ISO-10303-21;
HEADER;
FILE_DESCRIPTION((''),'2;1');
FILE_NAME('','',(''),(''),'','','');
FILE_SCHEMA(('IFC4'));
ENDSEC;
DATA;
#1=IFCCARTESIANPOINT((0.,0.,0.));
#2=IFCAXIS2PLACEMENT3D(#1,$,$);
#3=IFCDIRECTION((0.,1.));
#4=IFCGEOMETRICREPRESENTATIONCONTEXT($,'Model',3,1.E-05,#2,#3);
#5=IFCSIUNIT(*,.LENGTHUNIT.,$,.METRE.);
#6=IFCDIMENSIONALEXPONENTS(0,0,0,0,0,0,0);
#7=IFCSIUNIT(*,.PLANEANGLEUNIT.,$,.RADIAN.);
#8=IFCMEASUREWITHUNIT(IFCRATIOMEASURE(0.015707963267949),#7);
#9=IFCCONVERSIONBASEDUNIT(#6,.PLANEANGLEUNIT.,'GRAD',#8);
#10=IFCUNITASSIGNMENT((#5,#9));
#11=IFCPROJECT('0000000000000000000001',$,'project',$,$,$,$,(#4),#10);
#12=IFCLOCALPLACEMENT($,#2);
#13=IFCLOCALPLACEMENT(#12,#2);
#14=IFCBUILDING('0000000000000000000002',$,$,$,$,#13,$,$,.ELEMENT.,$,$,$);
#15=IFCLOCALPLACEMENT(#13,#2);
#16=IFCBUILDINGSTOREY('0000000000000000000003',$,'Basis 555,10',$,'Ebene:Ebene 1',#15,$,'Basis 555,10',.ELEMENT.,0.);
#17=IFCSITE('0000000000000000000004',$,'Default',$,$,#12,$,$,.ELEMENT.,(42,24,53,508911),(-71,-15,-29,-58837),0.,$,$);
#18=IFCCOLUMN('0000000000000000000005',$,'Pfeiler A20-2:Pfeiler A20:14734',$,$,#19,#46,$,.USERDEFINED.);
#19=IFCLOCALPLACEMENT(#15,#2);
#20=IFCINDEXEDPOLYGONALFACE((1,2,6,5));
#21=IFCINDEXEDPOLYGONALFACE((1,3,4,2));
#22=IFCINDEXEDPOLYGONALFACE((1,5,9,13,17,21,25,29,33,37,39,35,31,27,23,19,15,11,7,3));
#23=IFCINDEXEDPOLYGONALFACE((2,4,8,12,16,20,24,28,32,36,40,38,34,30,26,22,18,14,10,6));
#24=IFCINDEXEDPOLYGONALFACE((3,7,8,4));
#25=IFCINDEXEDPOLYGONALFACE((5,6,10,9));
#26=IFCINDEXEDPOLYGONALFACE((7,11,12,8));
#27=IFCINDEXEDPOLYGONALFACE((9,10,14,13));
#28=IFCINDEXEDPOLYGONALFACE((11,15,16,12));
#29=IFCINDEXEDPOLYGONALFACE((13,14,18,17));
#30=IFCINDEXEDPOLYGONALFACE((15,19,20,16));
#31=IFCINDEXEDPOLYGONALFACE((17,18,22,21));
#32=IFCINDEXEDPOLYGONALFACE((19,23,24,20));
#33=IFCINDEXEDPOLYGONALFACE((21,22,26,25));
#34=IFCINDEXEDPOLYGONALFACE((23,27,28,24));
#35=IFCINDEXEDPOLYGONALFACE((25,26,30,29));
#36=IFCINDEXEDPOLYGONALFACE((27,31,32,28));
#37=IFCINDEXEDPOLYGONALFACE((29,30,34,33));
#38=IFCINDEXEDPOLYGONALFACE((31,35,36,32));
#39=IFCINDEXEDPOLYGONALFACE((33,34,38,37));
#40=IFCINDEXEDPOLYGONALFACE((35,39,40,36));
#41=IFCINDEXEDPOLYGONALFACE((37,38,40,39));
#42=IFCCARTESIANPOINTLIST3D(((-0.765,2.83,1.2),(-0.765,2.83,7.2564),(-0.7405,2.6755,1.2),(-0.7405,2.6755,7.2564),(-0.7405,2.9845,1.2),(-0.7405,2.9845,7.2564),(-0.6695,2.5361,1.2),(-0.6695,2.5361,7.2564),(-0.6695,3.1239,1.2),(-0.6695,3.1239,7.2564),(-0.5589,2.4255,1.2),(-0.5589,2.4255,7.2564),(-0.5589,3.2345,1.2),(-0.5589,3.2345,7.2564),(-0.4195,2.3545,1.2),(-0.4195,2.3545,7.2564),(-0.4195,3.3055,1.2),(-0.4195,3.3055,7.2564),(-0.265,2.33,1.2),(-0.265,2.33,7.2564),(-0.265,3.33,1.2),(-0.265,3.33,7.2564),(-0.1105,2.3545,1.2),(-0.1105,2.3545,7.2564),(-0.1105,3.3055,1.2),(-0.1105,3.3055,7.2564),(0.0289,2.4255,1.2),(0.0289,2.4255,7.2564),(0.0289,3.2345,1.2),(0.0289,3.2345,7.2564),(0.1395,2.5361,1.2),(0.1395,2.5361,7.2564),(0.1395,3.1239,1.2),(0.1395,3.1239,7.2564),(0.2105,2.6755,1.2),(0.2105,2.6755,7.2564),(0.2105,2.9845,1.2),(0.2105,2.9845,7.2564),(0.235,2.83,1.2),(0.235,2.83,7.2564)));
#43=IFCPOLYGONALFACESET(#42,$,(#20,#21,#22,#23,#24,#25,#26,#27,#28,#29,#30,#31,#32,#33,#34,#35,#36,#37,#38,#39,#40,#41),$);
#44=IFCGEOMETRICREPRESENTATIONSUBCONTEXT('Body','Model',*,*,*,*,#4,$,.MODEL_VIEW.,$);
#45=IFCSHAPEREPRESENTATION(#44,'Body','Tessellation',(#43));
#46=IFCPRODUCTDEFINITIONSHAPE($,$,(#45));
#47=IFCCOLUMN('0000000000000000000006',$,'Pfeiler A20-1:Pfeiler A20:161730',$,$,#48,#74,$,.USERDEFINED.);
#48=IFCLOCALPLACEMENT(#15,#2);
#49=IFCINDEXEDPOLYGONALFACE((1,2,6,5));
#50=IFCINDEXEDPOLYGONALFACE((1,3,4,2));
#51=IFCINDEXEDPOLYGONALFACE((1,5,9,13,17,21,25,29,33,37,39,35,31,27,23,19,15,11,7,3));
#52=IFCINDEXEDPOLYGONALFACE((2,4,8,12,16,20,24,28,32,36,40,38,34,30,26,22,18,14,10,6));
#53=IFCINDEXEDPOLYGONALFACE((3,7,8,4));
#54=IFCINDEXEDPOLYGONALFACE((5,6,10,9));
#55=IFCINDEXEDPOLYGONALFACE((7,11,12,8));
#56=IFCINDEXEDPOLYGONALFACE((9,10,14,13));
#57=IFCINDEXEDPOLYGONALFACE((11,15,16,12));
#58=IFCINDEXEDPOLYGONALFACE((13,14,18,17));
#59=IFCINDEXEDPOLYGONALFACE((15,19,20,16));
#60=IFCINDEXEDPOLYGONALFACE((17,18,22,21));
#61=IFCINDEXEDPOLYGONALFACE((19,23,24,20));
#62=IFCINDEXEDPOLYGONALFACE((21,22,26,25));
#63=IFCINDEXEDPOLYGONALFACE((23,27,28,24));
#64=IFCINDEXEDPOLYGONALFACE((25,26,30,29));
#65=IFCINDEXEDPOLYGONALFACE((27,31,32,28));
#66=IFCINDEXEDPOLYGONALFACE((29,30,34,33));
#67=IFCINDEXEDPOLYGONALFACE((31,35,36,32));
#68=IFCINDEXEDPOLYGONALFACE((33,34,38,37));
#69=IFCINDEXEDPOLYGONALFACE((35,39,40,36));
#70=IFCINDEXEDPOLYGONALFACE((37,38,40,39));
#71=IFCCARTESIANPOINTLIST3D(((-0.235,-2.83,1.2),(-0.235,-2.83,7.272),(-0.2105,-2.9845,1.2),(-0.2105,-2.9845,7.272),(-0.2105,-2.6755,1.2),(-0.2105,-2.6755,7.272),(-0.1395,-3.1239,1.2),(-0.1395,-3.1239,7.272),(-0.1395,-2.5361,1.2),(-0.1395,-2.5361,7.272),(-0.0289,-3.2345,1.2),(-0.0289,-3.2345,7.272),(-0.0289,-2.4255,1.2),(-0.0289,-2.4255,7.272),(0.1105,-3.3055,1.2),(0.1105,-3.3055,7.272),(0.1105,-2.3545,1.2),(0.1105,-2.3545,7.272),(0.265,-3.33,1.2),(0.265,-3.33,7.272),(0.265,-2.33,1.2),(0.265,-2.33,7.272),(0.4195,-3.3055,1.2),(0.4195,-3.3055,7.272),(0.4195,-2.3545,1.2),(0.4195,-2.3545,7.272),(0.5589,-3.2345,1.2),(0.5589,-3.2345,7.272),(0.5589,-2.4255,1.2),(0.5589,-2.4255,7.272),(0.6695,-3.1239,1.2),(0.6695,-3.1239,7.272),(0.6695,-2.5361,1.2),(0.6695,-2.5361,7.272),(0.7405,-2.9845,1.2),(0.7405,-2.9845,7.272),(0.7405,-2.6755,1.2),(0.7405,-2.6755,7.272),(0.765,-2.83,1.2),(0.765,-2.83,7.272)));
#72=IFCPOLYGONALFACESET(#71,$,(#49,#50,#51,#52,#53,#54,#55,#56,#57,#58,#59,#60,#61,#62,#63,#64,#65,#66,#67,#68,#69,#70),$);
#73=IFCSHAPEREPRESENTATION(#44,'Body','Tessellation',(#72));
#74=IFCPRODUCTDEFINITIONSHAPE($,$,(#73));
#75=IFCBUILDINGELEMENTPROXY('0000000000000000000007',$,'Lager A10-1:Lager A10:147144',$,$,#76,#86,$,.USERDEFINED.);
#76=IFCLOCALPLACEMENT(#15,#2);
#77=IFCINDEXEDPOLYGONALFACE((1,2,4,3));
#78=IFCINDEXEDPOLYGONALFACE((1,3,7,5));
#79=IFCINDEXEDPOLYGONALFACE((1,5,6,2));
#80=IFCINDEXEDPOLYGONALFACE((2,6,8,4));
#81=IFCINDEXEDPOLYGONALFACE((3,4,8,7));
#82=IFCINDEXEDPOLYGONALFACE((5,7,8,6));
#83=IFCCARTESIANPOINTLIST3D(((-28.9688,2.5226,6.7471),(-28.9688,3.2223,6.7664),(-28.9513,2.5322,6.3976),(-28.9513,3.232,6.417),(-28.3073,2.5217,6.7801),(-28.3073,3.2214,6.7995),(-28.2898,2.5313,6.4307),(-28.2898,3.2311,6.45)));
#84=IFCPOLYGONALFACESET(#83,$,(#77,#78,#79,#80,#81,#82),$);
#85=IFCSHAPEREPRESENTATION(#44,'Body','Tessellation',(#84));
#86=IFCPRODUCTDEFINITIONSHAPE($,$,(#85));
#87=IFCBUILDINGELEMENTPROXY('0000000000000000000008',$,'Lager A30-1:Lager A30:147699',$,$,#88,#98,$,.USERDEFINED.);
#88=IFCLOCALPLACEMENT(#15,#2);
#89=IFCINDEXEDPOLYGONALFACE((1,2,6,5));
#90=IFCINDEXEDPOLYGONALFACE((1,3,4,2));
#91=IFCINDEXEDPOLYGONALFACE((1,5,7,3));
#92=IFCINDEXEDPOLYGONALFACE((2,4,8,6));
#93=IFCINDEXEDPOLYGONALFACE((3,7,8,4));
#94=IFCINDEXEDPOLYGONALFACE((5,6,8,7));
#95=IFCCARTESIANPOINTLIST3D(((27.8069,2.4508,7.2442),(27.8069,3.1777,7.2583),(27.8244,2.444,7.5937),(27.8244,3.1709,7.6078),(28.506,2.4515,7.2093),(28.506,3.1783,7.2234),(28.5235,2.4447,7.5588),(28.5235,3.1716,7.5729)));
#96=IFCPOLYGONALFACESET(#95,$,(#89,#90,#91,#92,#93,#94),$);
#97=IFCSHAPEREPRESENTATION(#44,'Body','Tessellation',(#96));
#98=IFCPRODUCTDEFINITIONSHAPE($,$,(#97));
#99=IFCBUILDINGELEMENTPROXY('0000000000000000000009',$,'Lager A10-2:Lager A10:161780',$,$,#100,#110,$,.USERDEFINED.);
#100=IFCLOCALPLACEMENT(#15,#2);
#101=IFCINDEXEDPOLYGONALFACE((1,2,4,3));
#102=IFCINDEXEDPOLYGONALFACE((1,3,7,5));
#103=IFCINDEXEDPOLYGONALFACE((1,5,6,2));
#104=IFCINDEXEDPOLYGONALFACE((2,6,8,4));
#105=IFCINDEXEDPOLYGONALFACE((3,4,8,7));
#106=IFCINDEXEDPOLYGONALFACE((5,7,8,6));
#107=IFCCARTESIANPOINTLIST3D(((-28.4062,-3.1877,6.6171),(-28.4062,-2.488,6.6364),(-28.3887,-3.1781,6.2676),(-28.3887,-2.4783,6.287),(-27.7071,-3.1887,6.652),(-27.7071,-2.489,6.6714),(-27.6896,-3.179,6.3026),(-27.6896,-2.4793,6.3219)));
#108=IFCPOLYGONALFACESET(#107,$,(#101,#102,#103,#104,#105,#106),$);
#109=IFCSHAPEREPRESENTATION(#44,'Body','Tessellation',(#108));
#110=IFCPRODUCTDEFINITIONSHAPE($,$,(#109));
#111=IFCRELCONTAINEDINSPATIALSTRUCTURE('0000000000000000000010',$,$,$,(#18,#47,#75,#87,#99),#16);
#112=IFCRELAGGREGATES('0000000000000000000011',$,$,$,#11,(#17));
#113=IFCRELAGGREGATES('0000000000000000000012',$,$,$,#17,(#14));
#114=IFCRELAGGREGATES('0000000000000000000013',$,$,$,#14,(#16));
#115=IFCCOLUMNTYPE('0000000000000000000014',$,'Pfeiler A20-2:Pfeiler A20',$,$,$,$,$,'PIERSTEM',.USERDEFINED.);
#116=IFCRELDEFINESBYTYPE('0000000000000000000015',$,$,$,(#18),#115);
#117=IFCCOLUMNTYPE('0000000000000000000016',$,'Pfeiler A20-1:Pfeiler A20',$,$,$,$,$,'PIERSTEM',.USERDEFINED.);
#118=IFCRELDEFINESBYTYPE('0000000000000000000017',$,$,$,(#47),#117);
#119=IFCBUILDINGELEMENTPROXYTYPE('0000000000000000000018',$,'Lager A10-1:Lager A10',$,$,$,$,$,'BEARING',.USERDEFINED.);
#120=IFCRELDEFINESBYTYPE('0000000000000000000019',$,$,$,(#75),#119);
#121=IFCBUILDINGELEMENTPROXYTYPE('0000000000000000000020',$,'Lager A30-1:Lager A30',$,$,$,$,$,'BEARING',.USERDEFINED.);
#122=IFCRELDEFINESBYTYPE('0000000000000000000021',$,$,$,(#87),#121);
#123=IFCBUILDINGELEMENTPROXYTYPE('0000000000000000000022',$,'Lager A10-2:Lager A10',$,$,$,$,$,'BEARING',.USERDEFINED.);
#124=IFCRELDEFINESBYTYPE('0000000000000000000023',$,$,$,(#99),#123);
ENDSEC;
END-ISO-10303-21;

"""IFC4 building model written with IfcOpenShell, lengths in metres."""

from ifc_helpers import new_model, entity, si_unit, converted_unit, direction, frame, origin, place, context, subcontext, project, spatial, indexed_curve, outline, extrude, source, transform, mapped, type_object, type_shapes, element, save


model = new_model("IFC4")

# Units and contexts
model_context = context("Model", 3, precision=1e-05, world=origin(), true_north=direction((0.0, 1.0)))
body_context = subcontext(model_context, "Body", "Model", "MODEL_VIEW")
ifc_project = project(units=[si_unit("LENGTHUNIT", "METRE"), converted_unit("PLANEANGLEUNIT", "GRAD", entity("IfcRatioMeasure", 0.015707963267949), si_unit("PLANEANGLEUNIT", "RADIAN"), dimensions=[0, 0, 0, 0, 0, 0, 0])], contexts=[model_context])

# Site, building, storey
site_placement = place(None, origin())
site = spatial("IfcSite", under=ifc_project, at=site_placement, Name="Default", CompositionType="ELEMENT", RefLatitude=(42, 24, 53, 508911), RefLongitude=(-71, -15, -29, -58837), RefElevation=0.0)
building_placement = place(site_placement, origin())
building = spatial("IfcBuilding", under=site, at=building_placement, CompositionType="ELEMENT")
storey_placement = place(building_placement, origin())
storey = spatial("IfcBuildingStorey", under=building, at=storey_placement, Name="Basis 555,10", ObjectType="Ebene:Ebene 1", LongName="Basis 555,10", CompositionType="ELEMENT", Elevation=0.0)

# Columns
column_type_1 = type_object("IfcColumnType", Name="Pfeiler A20-2:Pfeiler A20", ElementType="PIERSTEM", PredefinedType="USERDEFINED")
shared_shape_1 = source(origin(), body_context, "Body", "SweptSolid", [
    extrude(outline(indexed_curve([(0.5, 0.0), (0.4755, 0.1545), (0.4045, 0.2939), (0.2939, 0.4045), (0.1545, 0.4755), (0.0, 0.5), (-0.1545, 0.4755), (-0.2939, 0.4045), (-0.4045, 0.2939), (-0.4755, 0.1545), (-0.5, 0.0), (-0.4755, -0.1545), (-0.4045, -0.2939), (-0.2939, -0.4045), (-0.1545, -0.4755), (0.0, -0.5), (0.1545, -0.4755), (0.2939, -0.4045), (0.4045, -0.2939), (0.4755, -0.1545), (0.5, 0.0)], self_intersect=False)), frame((-0.265, 2.83, 1.2)), (0.0, 0.0, 1.0), 6.0564),
])
type_shapes(column_type_1, [shared_shape_1])
column_1_placement = place(storey_placement, origin())
element("IfcColumn", 1, at=column_1_placement, inside=storey, type_object=column_type_1, Name="Pfeiler A20-2:Pfeiler A20:14734", PredefinedType="USERDEFINED", context=body_context, shape_type="MappedRepresentation", body=[
    mapped(shared_shape_1, transform((0.0, 0.0, 0.0), scale=1.0)),
])
column_type_2 = type_object("IfcColumnType", Name="Pfeiler A20-1:Pfeiler A20", ElementType="PIERSTEM", PredefinedType="USERDEFINED")
shared_shape_2 = source(origin(), body_context, "Body", "SweptSolid", [
    extrude(outline(indexed_curve([(0.5, 0.0), (0.4755, 0.1545), (0.4045, 0.2939), (0.2939, 0.4045), (0.1545, 0.4755), (0.0, 0.5), (-0.1545, 0.4755), (-0.2939, 0.4045), (-0.4045, 0.2939), (-0.4755, 0.1545), (-0.5, 0.0), (-0.4755, -0.1545), (-0.4045, -0.2939), (-0.2939, -0.4045), (-0.1545, -0.4755), (0.0, -0.5), (0.1545, -0.4755), (0.2939, -0.4045), (0.4045, -0.2939), (0.4755, -0.1545), (0.5, 0.0)], self_intersect=False)), frame((0.265, -2.83, 1.2)), (0.0, 0.0, 1.0), 6.072),
])
type_shapes(column_type_2, [shared_shape_2])
column_2_placement = place(storey_placement, origin())
element("IfcColumn", 2, at=column_2_placement, inside=storey, type_object=column_type_2, Name="Pfeiler A20-1:Pfeiler A20:161730", PredefinedType="USERDEFINED", context=body_context, shape_type="MappedRepresentation", body=[
    mapped(shared_shape_2, transform((0.0, 0.0, 0.0), scale=1.0)),
])

# Building element proxies
building_element_proxy_type_1 = type_object("IfcBuildingElementProxyType", Name="Lager A10-1:Lager A10", ElementType="BEARING", PredefinedType="USERDEFINED")
shared_shape_3 = source(origin(), body_context, "Body", "SweptSolid", [
    extrude(outline(indexed_curve([(-0.175, -0.3311), (0.175, -0.3311), (0.175, 0.3311), (-0.175, 0.3311), (-0.175, -0.3311)], self_intersect=False)), frame((-28.6293, 2.527, 6.5889), z_axis=(0.0, 0.999617, 0.02768), x_axis=(0.049919, 0.027645, -0.998371)), (0.0, 0.0, 1.0), 0.7),
])
type_shapes(building_element_proxy_type_1, [shared_shape_3])
proxy_1_placement = place(storey_placement, origin())
element("IfcBuildingElementProxy", 3, at=proxy_1_placement, inside=storey, type_object=building_element_proxy_type_1, Name="Lager A10-1:Lager A10:147144", PredefinedType="USERDEFINED", context=body_context, shape_type="MappedRepresentation", body=[
    mapped(shared_shape_3, transform((0.0, 0.0, 0.0), scale=1.0)),
])
building_element_proxy_type_2 = type_object("IfcBuildingElementProxyType", Name="Lager A30-1:Lager A30", ElementType="BEARING", PredefinedType="USERDEFINED")
shared_shape_4 = source(origin(), body_context, "Body", "SweptSolid", [
    extrude(outline(indexed_curve([(-0.175, -0.35), (0.175, -0.35), (0.175, 0.35), (-0.175, 0.35), (-0.175, -0.35)], self_intersect=False)), frame((28.1652, 2.4477, 7.4015), z_axis=(0.0, 0.999812, 0.019407), x_axis=(-0.049928, 0.019382, -0.998565)), (0.0, 0.0, 1.0), 0.727),
])
type_shapes(building_element_proxy_type_2, [shared_shape_4])
proxy_2_placement = place(storey_placement, origin())
element("IfcBuildingElementProxy", 4, at=proxy_2_placement, inside=storey, type_object=building_element_proxy_type_2, Name="Lager A30-1:Lager A30:147699", PredefinedType="USERDEFINED", context=body_context, shape_type="MappedRepresentation", body=[
    mapped(shared_shape_4, transform((0.0, 0.0, 0.0), scale=1.0)),
])
building_element_proxy_type_3 = type_object("IfcBuildingElementProxyType", Name="Lager A10-2:Lager A10", ElementType="BEARING", PredefinedType="USERDEFINED")
shared_shape_5 = source(origin(), body_context, "Body", "SweptSolid", [
    extrude(outline(indexed_curve([(-0.175, -0.35), (0.175, -0.35), (0.175, 0.35), (-0.175, 0.35), (-0.175, -0.35)], self_intersect=False)), frame((-28.0479, -3.1834, 6.4598), z_axis=(0.0, 0.999617, 0.02768), x_axis=(0.049919, 0.027645, -0.998371)), (0.0, 0.0, 1.0), 0.7),
])
type_shapes(building_element_proxy_type_3, [shared_shape_5])
proxy_3_placement = place(storey_placement, origin())
element("IfcBuildingElementProxy", 5, at=proxy_3_placement, inside=storey, type_object=building_element_proxy_type_3, Name="Lager A10-2:Lager A10:161780", PredefinedType="USERDEFINED", context=body_context, shape_type="MappedRepresentation", body=[
    mapped(shared_shape_5, transform((0.0, 0.0, 0.0), scale=1.0)),
])

save(model, "model.ifc")
